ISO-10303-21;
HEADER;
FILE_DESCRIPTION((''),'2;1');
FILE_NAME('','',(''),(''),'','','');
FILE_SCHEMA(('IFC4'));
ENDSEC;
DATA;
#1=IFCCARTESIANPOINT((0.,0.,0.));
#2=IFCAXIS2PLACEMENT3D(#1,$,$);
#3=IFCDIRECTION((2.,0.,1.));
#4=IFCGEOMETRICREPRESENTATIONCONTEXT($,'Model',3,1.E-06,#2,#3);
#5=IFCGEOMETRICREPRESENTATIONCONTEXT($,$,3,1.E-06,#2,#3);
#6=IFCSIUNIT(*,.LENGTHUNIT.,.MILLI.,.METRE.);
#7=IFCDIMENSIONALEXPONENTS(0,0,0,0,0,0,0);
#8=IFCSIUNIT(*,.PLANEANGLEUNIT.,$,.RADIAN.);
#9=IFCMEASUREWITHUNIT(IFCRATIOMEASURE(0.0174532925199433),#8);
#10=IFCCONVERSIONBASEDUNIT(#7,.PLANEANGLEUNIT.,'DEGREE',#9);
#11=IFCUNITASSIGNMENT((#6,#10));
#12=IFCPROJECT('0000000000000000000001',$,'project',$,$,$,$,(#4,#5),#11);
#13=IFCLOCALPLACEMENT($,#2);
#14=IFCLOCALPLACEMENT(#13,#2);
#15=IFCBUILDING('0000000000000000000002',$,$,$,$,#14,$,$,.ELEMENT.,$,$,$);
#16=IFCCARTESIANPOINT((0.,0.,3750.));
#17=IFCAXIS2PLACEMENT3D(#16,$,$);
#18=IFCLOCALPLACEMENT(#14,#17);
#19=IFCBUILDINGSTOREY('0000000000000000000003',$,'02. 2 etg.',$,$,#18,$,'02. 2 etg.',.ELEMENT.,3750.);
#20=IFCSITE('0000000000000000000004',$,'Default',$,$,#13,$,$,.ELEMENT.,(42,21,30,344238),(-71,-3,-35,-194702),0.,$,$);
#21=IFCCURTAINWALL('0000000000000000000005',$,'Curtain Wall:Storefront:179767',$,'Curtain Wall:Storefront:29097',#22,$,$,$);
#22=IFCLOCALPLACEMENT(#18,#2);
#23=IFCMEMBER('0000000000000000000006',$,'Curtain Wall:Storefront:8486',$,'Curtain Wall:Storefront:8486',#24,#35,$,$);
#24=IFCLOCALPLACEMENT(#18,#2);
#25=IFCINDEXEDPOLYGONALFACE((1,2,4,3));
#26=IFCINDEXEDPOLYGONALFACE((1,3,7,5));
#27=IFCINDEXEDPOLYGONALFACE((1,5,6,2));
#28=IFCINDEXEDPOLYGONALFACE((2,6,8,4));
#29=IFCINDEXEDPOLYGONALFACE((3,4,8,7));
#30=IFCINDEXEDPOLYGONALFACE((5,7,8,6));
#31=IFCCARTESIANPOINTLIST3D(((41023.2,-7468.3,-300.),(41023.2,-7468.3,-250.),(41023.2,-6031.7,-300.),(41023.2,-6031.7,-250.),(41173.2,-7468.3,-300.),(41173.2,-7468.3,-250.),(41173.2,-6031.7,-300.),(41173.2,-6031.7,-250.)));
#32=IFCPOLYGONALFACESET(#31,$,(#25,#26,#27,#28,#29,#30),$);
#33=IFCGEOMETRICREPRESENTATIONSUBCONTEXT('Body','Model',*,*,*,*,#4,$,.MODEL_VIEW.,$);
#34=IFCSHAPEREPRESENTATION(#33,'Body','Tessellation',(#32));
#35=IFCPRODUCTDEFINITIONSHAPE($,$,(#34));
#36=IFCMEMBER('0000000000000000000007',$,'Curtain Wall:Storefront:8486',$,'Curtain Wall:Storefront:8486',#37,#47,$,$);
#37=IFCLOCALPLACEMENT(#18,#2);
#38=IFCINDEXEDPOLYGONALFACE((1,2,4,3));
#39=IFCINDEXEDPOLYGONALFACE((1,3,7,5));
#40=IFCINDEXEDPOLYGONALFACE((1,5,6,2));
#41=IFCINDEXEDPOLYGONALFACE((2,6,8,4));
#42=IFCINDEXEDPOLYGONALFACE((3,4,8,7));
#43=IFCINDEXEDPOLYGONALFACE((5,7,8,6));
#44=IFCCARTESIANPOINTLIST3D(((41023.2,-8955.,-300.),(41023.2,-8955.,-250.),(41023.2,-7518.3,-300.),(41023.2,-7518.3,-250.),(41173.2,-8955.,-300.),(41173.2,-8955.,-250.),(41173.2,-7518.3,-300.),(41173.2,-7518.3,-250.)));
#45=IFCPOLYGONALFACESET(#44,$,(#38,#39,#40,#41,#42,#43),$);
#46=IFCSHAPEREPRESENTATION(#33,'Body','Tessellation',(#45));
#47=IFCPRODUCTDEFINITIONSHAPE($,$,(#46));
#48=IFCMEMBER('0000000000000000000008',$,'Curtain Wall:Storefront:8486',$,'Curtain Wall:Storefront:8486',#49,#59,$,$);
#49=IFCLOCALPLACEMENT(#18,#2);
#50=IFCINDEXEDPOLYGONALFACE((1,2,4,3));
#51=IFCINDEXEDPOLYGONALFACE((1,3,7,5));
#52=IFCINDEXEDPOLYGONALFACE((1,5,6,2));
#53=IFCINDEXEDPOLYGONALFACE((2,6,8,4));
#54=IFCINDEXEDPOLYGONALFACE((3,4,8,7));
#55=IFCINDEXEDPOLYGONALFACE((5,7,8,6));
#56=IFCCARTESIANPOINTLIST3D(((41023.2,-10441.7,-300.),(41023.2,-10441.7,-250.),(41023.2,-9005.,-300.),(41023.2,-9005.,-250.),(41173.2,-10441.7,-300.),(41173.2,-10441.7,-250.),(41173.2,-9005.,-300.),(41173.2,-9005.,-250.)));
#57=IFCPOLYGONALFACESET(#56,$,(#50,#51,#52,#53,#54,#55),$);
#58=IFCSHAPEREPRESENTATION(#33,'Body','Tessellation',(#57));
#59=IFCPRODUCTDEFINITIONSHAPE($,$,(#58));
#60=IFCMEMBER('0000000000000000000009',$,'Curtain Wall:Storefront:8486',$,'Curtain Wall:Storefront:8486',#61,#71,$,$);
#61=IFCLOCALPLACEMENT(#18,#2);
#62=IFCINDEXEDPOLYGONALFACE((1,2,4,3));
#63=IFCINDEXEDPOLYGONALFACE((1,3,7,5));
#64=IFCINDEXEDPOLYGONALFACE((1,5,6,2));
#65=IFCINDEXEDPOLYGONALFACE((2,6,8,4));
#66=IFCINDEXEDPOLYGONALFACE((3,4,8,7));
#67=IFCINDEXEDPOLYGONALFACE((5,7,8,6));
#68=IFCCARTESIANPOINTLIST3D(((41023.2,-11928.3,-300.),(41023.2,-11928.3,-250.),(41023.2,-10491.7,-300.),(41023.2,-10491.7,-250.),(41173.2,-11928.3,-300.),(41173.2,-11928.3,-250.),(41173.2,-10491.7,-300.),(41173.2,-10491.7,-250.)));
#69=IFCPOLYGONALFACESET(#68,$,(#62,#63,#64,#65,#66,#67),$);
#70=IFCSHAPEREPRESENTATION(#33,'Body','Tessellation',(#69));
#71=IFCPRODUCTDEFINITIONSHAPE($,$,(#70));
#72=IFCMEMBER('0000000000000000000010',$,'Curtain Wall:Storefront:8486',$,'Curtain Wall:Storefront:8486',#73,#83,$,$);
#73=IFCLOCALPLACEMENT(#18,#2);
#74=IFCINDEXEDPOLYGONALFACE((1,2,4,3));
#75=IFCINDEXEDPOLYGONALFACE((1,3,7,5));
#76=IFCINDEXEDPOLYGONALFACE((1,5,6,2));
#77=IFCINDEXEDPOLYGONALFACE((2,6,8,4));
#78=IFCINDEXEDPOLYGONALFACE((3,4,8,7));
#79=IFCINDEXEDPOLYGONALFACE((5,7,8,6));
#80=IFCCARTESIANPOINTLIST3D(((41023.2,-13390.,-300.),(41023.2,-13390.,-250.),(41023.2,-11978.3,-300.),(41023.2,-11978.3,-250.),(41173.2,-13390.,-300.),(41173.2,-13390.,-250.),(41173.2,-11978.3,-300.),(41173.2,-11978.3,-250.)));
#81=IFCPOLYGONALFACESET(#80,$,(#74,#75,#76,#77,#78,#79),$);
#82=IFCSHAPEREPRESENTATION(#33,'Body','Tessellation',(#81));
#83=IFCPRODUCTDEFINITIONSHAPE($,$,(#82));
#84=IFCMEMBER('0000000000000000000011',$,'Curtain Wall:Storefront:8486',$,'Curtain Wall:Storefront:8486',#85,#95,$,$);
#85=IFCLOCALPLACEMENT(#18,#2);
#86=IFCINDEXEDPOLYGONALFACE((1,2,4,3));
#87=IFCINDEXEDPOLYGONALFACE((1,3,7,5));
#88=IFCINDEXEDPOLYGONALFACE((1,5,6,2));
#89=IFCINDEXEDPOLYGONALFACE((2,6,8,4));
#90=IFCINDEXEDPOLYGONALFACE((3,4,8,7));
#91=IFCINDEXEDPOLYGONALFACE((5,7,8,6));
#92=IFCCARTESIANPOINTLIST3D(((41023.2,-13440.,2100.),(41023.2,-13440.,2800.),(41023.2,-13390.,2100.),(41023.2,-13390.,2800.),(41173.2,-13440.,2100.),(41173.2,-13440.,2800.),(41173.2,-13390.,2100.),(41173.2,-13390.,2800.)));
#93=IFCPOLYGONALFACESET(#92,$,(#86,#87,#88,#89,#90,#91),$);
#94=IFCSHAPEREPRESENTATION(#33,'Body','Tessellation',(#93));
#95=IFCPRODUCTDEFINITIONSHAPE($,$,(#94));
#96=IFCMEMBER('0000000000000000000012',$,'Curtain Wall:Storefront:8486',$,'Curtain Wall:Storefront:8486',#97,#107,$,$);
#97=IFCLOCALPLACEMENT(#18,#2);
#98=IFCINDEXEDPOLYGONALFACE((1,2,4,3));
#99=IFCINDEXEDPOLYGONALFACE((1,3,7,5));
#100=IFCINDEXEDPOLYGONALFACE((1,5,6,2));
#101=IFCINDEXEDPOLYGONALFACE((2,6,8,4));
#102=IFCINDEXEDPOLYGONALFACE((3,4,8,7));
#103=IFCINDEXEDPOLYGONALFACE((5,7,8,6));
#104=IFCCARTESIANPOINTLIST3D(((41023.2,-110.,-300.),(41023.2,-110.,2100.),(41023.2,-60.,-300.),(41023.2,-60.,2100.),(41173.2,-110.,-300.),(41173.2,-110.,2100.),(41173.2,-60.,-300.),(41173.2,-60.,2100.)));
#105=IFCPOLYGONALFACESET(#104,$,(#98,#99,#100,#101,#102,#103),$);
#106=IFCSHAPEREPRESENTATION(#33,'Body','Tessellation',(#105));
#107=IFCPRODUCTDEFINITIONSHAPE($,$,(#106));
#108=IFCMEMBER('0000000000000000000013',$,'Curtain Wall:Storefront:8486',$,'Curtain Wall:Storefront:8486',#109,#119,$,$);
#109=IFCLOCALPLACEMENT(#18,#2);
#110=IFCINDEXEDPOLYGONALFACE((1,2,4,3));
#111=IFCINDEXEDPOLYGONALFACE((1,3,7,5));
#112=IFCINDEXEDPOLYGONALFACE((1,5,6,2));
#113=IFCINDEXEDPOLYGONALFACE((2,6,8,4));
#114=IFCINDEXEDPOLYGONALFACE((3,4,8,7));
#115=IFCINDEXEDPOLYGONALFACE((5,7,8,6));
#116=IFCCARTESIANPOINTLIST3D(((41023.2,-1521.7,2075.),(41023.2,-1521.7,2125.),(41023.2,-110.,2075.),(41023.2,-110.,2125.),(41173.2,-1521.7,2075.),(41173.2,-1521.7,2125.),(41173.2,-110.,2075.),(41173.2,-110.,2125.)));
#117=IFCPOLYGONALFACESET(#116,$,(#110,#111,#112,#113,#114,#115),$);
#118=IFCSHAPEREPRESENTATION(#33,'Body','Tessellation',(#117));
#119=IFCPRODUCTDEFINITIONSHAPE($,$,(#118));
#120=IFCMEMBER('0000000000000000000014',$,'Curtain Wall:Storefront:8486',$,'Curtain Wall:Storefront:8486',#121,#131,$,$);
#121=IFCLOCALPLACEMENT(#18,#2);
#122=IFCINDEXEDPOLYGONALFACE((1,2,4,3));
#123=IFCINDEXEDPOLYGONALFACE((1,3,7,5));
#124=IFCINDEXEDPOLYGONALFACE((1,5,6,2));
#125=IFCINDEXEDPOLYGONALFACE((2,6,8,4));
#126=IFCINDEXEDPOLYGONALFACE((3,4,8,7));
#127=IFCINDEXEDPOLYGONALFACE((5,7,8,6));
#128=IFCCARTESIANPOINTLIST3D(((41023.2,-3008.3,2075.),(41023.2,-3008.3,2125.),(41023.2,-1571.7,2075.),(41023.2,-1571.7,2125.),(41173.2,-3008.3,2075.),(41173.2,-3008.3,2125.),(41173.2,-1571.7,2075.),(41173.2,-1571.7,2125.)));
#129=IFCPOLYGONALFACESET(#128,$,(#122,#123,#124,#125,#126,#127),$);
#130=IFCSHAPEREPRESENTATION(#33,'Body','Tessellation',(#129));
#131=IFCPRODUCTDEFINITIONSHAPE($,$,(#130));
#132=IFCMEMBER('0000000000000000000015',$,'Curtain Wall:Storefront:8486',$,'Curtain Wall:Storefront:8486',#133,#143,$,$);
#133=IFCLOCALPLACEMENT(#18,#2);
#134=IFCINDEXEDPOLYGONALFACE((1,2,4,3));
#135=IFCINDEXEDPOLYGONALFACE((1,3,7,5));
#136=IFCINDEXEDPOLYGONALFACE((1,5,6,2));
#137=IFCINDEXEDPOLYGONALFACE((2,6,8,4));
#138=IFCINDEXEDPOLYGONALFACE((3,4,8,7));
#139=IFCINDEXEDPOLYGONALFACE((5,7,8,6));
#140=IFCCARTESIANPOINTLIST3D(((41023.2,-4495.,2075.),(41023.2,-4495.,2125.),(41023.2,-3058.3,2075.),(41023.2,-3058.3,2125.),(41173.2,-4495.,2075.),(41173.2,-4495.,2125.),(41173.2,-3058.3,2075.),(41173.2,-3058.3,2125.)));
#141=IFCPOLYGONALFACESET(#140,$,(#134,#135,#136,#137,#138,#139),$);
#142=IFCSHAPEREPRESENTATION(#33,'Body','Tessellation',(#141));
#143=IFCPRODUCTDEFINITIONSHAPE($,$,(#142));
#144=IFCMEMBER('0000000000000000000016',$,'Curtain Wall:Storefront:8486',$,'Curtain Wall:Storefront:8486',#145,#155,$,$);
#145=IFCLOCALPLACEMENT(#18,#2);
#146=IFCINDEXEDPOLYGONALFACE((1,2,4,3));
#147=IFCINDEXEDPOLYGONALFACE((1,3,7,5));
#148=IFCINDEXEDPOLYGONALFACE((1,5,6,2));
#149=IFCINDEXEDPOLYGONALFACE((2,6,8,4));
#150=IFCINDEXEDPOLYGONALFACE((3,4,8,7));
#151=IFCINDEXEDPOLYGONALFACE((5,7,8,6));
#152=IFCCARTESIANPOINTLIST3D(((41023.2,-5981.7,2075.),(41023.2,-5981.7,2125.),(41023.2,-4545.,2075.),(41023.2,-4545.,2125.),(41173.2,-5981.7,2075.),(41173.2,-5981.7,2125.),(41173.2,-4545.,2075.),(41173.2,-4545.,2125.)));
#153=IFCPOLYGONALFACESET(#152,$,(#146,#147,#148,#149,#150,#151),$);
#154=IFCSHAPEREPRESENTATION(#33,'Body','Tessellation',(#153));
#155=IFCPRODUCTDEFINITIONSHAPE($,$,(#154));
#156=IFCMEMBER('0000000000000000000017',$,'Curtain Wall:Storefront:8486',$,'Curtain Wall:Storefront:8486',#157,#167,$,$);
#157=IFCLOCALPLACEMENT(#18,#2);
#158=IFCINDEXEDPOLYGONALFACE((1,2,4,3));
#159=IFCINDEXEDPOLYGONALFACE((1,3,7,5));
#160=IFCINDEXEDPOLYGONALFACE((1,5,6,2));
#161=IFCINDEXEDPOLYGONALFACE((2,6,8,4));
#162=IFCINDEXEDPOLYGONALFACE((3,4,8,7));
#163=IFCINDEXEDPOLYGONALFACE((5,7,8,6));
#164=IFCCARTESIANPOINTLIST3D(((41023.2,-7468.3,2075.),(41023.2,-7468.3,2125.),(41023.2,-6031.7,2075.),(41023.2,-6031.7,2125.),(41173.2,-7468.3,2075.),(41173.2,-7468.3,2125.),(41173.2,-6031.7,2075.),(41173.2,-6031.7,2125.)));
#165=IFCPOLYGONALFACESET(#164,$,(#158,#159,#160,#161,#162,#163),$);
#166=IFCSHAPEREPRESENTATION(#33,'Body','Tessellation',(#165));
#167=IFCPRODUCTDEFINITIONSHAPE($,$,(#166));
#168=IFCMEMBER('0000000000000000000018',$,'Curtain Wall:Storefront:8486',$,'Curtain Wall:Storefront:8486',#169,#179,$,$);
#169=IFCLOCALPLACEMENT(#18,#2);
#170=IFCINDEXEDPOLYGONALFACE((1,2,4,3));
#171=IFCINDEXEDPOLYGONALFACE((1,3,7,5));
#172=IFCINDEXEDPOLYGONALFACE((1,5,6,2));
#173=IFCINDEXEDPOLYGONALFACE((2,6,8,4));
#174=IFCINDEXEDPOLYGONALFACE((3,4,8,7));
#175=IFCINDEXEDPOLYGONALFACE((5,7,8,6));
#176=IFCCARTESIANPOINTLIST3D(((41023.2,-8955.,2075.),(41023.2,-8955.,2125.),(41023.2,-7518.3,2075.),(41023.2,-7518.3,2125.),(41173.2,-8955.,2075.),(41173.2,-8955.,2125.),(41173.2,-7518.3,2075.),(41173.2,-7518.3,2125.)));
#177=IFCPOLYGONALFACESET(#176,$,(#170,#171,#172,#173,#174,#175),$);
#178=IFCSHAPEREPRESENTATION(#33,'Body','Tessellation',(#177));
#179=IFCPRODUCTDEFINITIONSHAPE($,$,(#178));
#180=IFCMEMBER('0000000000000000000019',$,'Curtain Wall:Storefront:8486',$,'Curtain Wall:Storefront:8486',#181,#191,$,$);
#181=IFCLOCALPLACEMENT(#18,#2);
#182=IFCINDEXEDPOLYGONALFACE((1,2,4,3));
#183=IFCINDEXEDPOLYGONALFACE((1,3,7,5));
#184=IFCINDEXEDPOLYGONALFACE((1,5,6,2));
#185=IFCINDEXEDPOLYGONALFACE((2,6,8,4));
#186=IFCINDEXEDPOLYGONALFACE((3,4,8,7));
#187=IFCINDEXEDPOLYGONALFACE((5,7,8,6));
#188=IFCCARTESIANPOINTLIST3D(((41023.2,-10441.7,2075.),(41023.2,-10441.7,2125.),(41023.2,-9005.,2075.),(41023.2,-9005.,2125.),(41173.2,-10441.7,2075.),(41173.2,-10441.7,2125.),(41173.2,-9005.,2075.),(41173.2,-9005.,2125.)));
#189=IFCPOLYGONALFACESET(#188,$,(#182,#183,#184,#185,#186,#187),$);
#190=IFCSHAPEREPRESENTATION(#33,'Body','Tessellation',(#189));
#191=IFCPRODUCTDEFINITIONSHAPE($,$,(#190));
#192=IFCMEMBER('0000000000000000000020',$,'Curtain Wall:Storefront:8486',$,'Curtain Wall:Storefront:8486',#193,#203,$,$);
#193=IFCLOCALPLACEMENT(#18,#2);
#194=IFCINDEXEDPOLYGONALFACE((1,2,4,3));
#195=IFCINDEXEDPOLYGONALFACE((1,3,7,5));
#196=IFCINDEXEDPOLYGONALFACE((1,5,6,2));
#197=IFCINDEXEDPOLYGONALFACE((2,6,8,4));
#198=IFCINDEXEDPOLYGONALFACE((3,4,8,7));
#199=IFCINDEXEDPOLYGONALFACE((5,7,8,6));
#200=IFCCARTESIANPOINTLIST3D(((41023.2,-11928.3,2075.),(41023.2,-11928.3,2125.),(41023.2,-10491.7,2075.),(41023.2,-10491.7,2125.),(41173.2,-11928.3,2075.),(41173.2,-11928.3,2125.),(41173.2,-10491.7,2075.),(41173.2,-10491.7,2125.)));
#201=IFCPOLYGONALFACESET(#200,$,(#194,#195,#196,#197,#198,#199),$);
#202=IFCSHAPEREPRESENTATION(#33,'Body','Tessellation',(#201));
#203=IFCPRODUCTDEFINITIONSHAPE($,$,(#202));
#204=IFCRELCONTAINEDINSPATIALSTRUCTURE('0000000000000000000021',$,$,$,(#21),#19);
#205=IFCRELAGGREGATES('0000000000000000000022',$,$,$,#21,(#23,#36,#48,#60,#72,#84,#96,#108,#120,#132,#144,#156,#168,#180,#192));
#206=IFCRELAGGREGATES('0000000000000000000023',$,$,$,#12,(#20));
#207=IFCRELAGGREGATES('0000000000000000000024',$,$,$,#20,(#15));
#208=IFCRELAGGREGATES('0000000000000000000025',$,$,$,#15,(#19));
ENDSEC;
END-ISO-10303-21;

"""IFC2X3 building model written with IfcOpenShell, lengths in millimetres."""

from ifc_helpers import new_model, entity, si_unit, converted_unit, direction, frame, frame_2d, origin, origin_2d_with_axis, place, context, subcontext, project, spatial, rectangle, extrude, element, aggregate, save


model = new_model("IFC2X3")

# Units and contexts
model_context = context("Model", 3, precision=1e-06, world=origin(), true_north=direction((2.0, 0.0, 1.0)))
context_of_model = context(None, 3, precision=1e-06, world=origin(), true_north=direction((2.0, 0.0, 1.0)))
body_context = subcontext(model_context, "Body", "Model", "MODEL_VIEW")
ifc_project = project(units=[si_unit("LENGTHUNIT", "METRE", prefix="MILLI"), converted_unit("PLANEANGLEUNIT", "DEGREE", entity("IfcRatioMeasure", 0.0174532925199433), si_unit("PLANEANGLEUNIT", "RADIAN"), dimensions=[0, 0, 0, 0, 0, 0, 0])], contexts=[model_context, context_of_model])

# Site, building, storey
site_placement = place(None, origin())
site = spatial("IfcSite", under=ifc_project, at=site_placement, Name="Default", CompositionType="ELEMENT", RefLatitude=(42, 21, 30, 344238), RefLongitude=(-71, -3, -35, -194702), RefElevation=0.0)
building_placement = place(site_placement, origin())
building = spatial("IfcBuilding", under=site, at=building_placement, CompositionType="ELEMENT")
storey_placement = place(building_placement, frame((0.0, 0.0, 3750.0)))
storey = spatial("IfcBuildingStorey", under=building, at=storey_placement, Name="02. 2 etg.", LongName="02. 2 etg.", CompositionType="ELEMENT", Elevation=3750.0)

# Curtain wall, members
curtain_wall_placement = place(storey_placement, origin())
curtain_wall = element("IfcCurtainWall", 1, at=curtain_wall_placement, inside=storey, Name="Curtain Wall:Storefront:179767", ObjectType="Curtain Wall:Storefront:29097")
member_1_placement = place(storey_placement, origin())
member_1 = element("IfcMember", 2, at=member_1_placement, Name="Curtain Wall:Storefront:8486", ObjectType="Curtain Wall:Storefront:8486", context=body_context, shape_type="SweptSolid", body=[
    extrude(rectangle(XDim=1436.7, YDim=150.0, at=origin_2d_with_axis()), frame((41098.2, -6750.0, -300.0), z_axis=(0.0, 0.0, 1.0), x_axis=(0.0, -1.0, 0.0)), (0.0, 0.0, 1.0), 50.0),
])
member_2_placement = place(storey_placement, origin())
member_2 = element("IfcMember", 3, at=member_2_placement, Name="Curtain Wall:Storefront:8486", ObjectType="Curtain Wall:Storefront:8486", context=body_context, shape_type="SweptSolid", body=[
    extrude(rectangle(XDim=1436.7, YDim=150.0, at=frame_2d((0.0, 0.0), x_axis=(1.0, 0.0))), frame((41098.2, -8236.7, -300.0), z_axis=(0.0, 0.0, 1.0), x_axis=(0.0, -1.0, 0.0)), (0.0, 0.0, 1.0), 50.0),
])
member_3_placement = place(storey_placement, origin())
member_3 = element("IfcMember", 4, at=member_3_placement, Name="Curtain Wall:Storefront:8486", ObjectType="Curtain Wall:Storefront:8486", context=body_context, shape_type="SweptSolid", body=[
    extrude(rectangle(XDim=1436.7, YDim=150.0, at=frame_2d((0.0, 0.0), x_axis=(1.0, 0.0))), frame((41098.2, -9723.3, -300.0), z_axis=(0.0, 0.0, 1.0), x_axis=(0.0, -1.0, 0.0)), (0.0, 0.0, 1.0), 50.0),
])
member_4_placement = place(storey_placement, origin())
member_4 = element("IfcMember", 5, at=member_4_placement, Name="Curtain Wall:Storefront:8486", ObjectType="Curtain Wall:Storefront:8486", context=body_context, shape_type="SweptSolid", body=[
    extrude(rectangle(XDim=1436.7, YDim=150.0, at=frame_2d((0.0, 0.0), x_axis=(1.0, 0.0))), frame((41098.2, -11210.0, -300.0), z_axis=(0.0, 0.0, 1.0), x_axis=(0.0, -1.0, 0.0)), (0.0, 0.0, 1.0), 50.0),
])
member_5_placement = place(storey_placement, origin())
member_5 = element("IfcMember", 6, at=member_5_placement, Name="Curtain Wall:Storefront:8486", ObjectType="Curtain Wall:Storefront:8486", context=body_context, shape_type="SweptSolid", body=[
    extrude(rectangle(XDim=1411.7, YDim=150.0, at=frame_2d((0.0, 0.0), x_axis=(1.0, 0.0))), frame((41098.2, -12684.2, -300.0), z_axis=(0.0, 0.0, 1.0), x_axis=(0.0, -1.0, 0.0)), (0.0, 0.0, 1.0), 50.0),
])
member_6_placement = place(storey_placement, origin())
member_6 = element("IfcMember", 7, at=member_6_placement, Name="Curtain Wall:Storefront:8486", ObjectType="Curtain Wall:Storefront:8486", context=body_context, shape_type="SweptSolid", body=[
    extrude(rectangle(XDim=150.0, YDim=50.0, at=frame_2d((0.0, 0.0), x_axis=(1.0, 0.0))), frame((41098.2, -13415.0, 2100.0)), (0.0, 0.0, 1.0), 700.0),
])
member_7_placement = place(storey_placement, origin())
member_7 = element("IfcMember", 8, at=member_7_placement, Name="Curtain Wall:Storefront:8486", ObjectType="Curtain Wall:Storefront:8486", context=body_context, shape_type="SweptSolid", body=[
    extrude(rectangle(XDim=50.0, YDim=150.0, at=frame_2d((0.0, 0.0), x_axis=(1.0, 0.0))), frame((41098.2, -85.0, -300.0), z_axis=(0.0, 0.0, 1.0), x_axis=(0.0, -1.0, 0.0)), (0.0, 0.0, 1.0), 2400.0),
])
member_8_placement = place(storey_placement, origin())
member_8 = element("IfcMember", 9, at=member_8_placement, Name="Curtain Wall:Storefront:8486", ObjectType="Curtain Wall:Storefront:8486", context=body_context, shape_type="SweptSolid", body=[
    extrude(rectangle(XDim=1411.7, YDim=150.0, at=origin_2d_with_axis()), frame((41098.2, -815.8, 2075.0), z_axis=(0.0, 0.0, 1.0), x_axis=(0.0, 1.0, 0.0)), (0.0, 0.0, 1.0), 50.0),
])
member_9_placement = place(storey_placement, origin())
member_9 = element("IfcMember", 10, at=member_9_placement, Name="Curtain Wall:Storefront:8486", ObjectType="Curtain Wall:Storefront:8486", context=body_context, shape_type="SweptSolid", body=[
    extrude(rectangle(XDim=1436.7, YDim=150.0, at=frame_2d((0.0, 0.0), x_axis=(1.0, 0.0))), frame((41098.2, -2290.0, 2075.0), z_axis=(0.0, 0.0, 1.0), x_axis=(0.0, 1.0, 0.0)), (0.0, 0.0, 1.0), 50.0),
])
member_10_placement = place(storey_placement, origin())
member_10 = element("IfcMember", 11, at=member_10_placement, Name="Curtain Wall:Storefront:8486", ObjectType="Curtain Wall:Storefront:8486", context=body_context, shape_type="SweptSolid", body=[
    extrude(rectangle(XDim=1436.7, YDim=150.0, at=origin_2d_with_axis()), frame((41098.2, -3776.7, 2075.0), z_axis=(0.0, 0.0, 1.0), x_axis=(0.0, 1.0, 0.0)), (0.0, 0.0, 1.0), 50.0),
])
member_11_placement = place(storey_placement, origin())
member_11 = element("IfcMember", 12, at=member_11_placement, Name="Curtain Wall:Storefront:8486", ObjectType="Curtain Wall:Storefront:8486", context=body_context, shape_type="SweptSolid", body=[
    extrude(rectangle(XDim=1436.7, YDim=150.0, at=frame_2d((0.0, 0.0), x_axis=(1.0, 0.0))), frame((41098.2, -5263.3, 2075.0), z_axis=(0.0, 0.0, 1.0), x_axis=(0.0, 1.0, 0.0)), (0.0, 0.0, 1.0), 50.0),
])
member_12_placement = place(storey_placement, origin())
member_12 = element("IfcMember", 13, at=member_12_placement, Name="Curtain Wall:Storefront:8486", ObjectType="Curtain Wall:Storefront:8486", context=body_context, shape_type="SweptSolid", body=[
    extrude(rectangle(XDim=1436.7, YDim=150.0, at=frame_2d((0.0, 0.0), x_axis=(1.0, 0.0))), frame((41098.2, -6750.0, 2075.0), z_axis=(0.0, 0.0, 1.0), x_axis=(0.0, 1.0, 0.0)), (0.0, 0.0, 1.0), 50.0),
])
member_13_placement = place(storey_placement, origin())
member_13 = element("IfcMember", 14, at=member_13_placement, Name="Curtain Wall:Storefront:8486", ObjectType="Curtain Wall:Storefront:8486", context=body_context, shape_type="SweptSolid", body=[
    extrude(rectangle(XDim=1436.7, YDim=150.0, at=frame_2d((0.0, 0.0), x_axis=(1.0, 0.0))), frame((41098.2, -8236.7, 2075.0), z_axis=(0.0, 0.0, 1.0), x_axis=(0.0, 1.0, 0.0)), (0.0, 0.0, 1.0), 50.0),
])
member_14_placement = place(storey_placement, origin())
member_14 = element("IfcMember", 15, at=member_14_placement, Name="Curtain Wall:Storefront:8486", ObjectType="Curtain Wall:Storefront:8486", context=body_context, shape_type="SweptSolid", body=[
    extrude(rectangle(XDim=1436.7, YDim=150.0, at=frame_2d((0.0, 0.0), x_axis=(1.0, 0.0))), frame((41098.2, -9723.3, 2075.0), z_axis=(0.0, 0.0, 1.0), x_axis=(0.0, 1.0, 0.0)), (0.0, 0.0, 1.0), 50.0),
])
member_15_placement = place(storey_placement, origin())
member_15 = element("IfcMember", 16, at=member_15_placement, Name="Curtain Wall:Storefront:8486", ObjectType="Curtain Wall:Storefront:8486", context=body_context, shape_type="SweptSolid", body=[
    extrude(rectangle(XDim=1436.7, YDim=150.0, at=frame_2d((0.0, 0.0), x_axis=(1.0, 0.0))), frame((41098.2, -11210.0, 2075.0), z_axis=(0.0, 0.0, 1.0), x_axis=(0.0, 1.0, 0.0)), (0.0, 0.0, 1.0), 50.0),
])
aggregate(curtain_wall, [member_1, member_2, member_3, member_4, member_5, member_6, member_7, member_8, member_9, member_10, member_11, member_12, member_13, member_14, member_15])

save(model, "model.ifc")
